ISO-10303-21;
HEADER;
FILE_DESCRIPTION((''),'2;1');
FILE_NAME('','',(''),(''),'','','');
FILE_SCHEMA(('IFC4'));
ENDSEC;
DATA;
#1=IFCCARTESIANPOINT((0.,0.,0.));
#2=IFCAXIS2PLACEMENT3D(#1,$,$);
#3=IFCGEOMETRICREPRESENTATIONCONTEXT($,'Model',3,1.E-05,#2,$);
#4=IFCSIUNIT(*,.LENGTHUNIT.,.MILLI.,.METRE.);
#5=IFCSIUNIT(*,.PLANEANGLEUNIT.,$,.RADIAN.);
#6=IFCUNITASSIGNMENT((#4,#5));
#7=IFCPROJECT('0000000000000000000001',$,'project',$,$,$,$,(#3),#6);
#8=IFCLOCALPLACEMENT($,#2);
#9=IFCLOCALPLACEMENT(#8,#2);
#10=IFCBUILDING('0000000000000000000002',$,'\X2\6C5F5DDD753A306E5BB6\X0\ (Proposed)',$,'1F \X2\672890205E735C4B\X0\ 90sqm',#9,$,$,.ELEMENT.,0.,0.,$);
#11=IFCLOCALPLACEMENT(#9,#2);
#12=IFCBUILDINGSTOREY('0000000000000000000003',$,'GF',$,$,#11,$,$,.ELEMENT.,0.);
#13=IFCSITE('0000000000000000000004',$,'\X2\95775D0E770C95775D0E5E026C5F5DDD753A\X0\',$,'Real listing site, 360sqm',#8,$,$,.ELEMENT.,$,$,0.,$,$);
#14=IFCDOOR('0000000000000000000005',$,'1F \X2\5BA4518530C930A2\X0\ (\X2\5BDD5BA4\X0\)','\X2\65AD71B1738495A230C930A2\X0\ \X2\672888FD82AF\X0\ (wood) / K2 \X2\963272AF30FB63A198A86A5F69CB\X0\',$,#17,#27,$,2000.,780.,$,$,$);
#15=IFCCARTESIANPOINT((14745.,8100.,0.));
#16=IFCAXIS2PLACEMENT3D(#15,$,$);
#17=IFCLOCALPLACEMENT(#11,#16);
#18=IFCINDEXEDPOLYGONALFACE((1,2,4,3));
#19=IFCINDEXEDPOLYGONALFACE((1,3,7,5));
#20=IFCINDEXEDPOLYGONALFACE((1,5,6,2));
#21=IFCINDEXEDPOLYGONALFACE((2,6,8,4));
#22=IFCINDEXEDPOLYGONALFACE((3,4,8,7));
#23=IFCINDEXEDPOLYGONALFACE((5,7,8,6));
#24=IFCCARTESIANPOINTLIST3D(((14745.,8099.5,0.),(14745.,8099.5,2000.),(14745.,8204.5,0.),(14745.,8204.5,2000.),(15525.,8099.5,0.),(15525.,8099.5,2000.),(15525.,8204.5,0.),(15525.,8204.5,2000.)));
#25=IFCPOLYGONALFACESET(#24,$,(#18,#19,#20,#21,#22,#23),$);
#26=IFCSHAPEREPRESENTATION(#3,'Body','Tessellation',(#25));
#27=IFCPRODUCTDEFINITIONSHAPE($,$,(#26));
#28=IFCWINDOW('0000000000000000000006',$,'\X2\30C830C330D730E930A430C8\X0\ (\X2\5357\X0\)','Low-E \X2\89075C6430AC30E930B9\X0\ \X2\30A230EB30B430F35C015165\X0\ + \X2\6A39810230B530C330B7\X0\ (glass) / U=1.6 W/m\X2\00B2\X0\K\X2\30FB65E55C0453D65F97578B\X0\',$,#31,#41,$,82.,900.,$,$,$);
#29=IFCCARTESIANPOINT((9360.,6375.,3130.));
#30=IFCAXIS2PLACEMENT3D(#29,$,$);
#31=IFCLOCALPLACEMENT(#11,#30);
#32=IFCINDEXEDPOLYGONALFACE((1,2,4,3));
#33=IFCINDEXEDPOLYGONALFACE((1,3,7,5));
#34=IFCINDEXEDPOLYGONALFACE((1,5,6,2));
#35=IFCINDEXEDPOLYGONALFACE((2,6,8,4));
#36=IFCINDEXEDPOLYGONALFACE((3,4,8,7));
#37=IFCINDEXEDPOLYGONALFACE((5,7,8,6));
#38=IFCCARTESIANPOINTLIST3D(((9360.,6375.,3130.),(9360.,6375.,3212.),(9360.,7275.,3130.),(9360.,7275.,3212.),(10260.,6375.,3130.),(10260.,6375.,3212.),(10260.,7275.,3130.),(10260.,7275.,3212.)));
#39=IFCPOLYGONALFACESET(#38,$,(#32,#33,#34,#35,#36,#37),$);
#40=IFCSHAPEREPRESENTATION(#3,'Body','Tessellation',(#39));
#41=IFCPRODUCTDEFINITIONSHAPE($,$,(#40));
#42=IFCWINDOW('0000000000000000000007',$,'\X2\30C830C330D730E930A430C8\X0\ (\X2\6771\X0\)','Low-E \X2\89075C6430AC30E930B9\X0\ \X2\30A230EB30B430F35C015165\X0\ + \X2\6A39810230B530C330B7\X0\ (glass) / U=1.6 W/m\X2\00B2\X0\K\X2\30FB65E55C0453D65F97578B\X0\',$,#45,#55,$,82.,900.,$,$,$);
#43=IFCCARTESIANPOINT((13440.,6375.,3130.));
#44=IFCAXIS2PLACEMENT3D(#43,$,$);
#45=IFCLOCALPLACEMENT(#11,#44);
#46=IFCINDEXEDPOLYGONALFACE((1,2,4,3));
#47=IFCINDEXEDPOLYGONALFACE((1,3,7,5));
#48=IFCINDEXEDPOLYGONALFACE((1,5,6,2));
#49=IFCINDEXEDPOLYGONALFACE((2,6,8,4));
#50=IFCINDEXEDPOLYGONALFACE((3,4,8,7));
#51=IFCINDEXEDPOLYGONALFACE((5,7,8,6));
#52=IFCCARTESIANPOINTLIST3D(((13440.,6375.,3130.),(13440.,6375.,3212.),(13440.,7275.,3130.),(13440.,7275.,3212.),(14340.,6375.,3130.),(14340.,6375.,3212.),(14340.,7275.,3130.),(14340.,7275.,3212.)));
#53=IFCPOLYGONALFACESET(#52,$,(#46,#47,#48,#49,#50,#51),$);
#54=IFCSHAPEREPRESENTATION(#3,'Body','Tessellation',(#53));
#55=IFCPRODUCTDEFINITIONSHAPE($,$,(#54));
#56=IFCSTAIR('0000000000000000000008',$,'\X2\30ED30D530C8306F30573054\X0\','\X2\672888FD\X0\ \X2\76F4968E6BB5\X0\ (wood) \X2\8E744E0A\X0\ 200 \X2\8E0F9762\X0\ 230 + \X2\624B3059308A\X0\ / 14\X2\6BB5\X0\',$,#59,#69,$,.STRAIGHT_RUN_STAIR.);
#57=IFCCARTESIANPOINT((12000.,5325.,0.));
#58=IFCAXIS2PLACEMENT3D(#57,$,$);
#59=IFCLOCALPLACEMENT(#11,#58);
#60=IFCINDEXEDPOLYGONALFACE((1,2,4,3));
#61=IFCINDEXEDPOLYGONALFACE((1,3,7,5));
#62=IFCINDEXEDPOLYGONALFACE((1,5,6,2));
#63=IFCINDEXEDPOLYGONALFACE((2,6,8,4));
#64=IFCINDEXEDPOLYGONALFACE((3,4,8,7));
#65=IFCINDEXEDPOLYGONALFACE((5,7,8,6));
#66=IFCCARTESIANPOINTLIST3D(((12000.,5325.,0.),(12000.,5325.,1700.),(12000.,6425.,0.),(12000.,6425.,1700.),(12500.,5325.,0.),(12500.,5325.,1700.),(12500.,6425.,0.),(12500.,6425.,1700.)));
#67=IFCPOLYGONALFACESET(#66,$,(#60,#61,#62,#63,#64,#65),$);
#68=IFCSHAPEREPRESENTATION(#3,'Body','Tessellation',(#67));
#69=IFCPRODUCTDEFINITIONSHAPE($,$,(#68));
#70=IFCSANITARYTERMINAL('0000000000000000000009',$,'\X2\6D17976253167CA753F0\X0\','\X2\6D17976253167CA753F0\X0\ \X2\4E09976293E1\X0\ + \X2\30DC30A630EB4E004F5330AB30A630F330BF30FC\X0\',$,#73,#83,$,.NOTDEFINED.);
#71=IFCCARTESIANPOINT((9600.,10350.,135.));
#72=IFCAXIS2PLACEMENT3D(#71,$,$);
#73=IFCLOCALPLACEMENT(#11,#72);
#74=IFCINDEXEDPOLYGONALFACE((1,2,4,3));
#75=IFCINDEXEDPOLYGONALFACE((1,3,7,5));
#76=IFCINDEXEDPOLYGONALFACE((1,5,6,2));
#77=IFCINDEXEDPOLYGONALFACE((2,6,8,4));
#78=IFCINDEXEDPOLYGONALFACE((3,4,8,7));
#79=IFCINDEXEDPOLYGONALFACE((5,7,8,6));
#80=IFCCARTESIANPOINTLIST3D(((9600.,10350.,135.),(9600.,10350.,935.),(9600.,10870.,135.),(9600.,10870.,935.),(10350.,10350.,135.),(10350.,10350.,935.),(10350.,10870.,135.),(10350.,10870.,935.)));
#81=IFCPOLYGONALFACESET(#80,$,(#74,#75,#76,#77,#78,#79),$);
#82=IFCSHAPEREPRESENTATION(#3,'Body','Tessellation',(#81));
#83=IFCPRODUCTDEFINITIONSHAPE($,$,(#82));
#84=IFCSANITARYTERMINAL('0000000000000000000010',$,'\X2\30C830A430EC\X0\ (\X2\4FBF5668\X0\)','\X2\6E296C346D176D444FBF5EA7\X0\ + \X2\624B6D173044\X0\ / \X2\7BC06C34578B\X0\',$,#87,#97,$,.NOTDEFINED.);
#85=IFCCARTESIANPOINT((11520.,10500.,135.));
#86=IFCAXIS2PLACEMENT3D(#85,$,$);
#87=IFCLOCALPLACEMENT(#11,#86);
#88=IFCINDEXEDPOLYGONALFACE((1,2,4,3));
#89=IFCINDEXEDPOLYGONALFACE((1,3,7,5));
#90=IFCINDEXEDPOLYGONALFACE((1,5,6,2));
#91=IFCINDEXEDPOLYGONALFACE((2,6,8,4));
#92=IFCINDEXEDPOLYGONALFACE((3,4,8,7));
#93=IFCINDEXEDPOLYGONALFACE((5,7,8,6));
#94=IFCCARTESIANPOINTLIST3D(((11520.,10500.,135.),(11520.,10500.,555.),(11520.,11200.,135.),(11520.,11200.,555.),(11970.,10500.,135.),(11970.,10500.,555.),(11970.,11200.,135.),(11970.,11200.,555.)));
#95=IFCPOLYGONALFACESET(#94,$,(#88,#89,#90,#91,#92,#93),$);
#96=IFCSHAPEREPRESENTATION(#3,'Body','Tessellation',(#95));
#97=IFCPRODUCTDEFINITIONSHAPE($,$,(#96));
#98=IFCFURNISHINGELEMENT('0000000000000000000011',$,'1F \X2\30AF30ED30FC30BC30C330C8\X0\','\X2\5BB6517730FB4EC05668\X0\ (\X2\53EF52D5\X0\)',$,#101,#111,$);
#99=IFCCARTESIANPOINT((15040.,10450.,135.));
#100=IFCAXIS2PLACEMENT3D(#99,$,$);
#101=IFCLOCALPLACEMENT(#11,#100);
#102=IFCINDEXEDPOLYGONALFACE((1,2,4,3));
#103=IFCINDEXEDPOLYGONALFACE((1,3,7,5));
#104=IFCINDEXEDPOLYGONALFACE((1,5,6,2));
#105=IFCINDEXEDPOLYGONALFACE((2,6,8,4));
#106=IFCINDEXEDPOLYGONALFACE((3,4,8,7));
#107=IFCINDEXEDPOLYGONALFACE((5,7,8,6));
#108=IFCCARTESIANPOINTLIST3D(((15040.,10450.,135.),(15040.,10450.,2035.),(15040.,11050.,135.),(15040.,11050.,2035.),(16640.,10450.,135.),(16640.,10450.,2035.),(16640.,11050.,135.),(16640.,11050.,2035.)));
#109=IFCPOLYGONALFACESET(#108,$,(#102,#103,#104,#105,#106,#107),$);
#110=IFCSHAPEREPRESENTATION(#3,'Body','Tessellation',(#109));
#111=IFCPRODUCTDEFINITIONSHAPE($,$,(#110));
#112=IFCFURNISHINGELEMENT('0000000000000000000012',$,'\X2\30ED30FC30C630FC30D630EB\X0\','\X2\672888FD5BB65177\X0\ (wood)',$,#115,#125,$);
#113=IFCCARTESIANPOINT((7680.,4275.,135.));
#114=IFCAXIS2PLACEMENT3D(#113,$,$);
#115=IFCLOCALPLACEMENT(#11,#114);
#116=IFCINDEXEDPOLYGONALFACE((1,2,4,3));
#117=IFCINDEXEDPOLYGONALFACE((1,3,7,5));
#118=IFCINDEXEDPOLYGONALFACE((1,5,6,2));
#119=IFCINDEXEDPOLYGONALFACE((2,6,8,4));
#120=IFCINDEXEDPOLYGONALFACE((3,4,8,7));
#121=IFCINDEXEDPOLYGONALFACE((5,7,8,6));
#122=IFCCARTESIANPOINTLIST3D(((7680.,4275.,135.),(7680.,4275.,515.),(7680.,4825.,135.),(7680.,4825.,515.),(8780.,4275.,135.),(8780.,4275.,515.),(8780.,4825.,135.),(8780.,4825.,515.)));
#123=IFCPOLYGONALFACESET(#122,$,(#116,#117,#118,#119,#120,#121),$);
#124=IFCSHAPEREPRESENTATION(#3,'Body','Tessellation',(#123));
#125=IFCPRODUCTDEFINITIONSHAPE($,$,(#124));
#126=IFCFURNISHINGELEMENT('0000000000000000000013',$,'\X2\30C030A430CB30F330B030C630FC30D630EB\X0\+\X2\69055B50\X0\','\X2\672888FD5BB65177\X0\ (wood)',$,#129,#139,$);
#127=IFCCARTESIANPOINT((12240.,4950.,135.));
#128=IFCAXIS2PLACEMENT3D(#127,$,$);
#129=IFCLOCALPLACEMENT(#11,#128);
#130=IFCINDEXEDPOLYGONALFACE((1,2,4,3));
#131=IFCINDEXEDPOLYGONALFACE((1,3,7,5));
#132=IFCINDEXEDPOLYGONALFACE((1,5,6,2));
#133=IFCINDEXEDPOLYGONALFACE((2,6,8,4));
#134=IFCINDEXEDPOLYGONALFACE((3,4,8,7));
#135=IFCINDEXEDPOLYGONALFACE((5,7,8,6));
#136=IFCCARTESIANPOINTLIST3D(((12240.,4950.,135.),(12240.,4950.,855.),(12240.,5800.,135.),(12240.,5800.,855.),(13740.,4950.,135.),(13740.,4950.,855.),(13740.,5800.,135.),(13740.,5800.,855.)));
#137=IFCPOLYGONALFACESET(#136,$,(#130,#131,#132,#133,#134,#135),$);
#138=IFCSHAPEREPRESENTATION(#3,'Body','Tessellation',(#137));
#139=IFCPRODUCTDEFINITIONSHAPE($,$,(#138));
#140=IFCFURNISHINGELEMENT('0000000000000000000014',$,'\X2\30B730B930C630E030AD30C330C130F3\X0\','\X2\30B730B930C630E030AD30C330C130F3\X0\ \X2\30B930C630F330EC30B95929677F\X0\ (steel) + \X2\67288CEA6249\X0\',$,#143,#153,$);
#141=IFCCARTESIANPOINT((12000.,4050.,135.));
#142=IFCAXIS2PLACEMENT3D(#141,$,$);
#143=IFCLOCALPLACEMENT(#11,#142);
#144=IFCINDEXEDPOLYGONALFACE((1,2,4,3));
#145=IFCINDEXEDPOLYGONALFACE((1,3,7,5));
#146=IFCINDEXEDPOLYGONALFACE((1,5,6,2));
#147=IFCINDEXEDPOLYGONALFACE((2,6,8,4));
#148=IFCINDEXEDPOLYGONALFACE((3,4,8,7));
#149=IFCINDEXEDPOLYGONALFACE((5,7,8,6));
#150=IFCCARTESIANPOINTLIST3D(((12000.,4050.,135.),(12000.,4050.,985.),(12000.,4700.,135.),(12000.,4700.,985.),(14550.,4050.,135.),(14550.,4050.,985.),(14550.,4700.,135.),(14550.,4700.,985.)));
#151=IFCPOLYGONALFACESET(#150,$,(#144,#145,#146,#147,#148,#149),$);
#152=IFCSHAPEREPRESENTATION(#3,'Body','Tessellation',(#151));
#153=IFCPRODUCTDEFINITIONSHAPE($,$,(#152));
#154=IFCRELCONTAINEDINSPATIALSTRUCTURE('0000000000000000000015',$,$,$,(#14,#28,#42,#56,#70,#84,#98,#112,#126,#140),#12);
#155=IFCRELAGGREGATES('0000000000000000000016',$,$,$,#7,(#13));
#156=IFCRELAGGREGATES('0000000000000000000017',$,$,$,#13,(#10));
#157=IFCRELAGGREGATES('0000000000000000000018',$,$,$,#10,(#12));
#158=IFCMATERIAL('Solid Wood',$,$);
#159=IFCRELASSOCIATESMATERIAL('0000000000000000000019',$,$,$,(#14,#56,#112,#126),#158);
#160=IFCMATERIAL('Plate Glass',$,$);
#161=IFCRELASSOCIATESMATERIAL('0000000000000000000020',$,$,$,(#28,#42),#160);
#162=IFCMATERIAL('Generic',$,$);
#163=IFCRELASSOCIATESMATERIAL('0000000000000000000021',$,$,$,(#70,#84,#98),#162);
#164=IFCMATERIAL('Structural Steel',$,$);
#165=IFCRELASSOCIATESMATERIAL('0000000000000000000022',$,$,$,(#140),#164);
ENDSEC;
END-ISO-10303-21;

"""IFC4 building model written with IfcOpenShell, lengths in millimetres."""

from ifc_helpers import new_model, si_unit, frame, frame_2d, origin, place, context, project, spatial, rectangle, extrude, material, element, save


model = new_model("IFC4")

# Units and contexts
model_context = context("Model", 3, precision=1e-05, world=origin())
ifc_project = project(units=[si_unit("LENGTHUNIT", "METRE", prefix="MILLI"), si_unit("PLANEANGLEUNIT", "RADIAN")], contexts=[model_context])

# Site, building, storey
site_placement = place(None, origin())
site = spatial("IfcSite", under=ifc_project, at=site_placement, Name="長崎県長崎市江川町", ObjectType="Real listing site, 360sqm", CompositionType="ELEMENT", RefElevation=0.0)
building_placement = place(site_placement, origin())
building = spatial("IfcBuilding", under=site, at=building_placement, Name="江川町の家 (Proposed)", ObjectType="1F 木造平屋 90sqm", CompositionType="ELEMENT", ElevationOfRefHeight=0.0, ElevationOfTerrain=0.0)
storey_placement = place(building_placement, origin())
storey = spatial("IfcBuildingStorey", under=building, at=storey_placement, Name="GF", CompositionType="ELEMENT", Elevation=0.0)

# Shared definitions
ifc_material_1 = material(Name="Solid Wood")
ifc_material_2 = material(Name="Plate Glass")

# Door
door_placement = place(storey_placement, frame((14745.0, 8100.0, 0.0)))
element("IfcDoor", 1, at=door_placement, inside=storey, material=ifc_material_1, Name="1F 室内ドア (寝室)", Description="断熱玄関ドア 木製芯 (wood) / K2 防犯・採風機構", OverallHeight=2000.0, OverallWidth=780.0, context=model_context, shape_type="SweptSolid", body=[
    extrude(rectangle(XDim=780.0, YDim=105.0, at=frame_2d((390.0, 52.0))), frame((14745.0, 8100.0, 0.0)), (0.0, 0.0, 1.0), 2000.0),
])

# Windows
window_1_placement = place(storey_placement, frame((9360.0, 6375.0, 3130.0)))
element("IfcWindow", 2, at=window_1_placement, inside=storey, material=ifc_material_2, Name="トップライト (南)", Description="Low-E 複層ガラス アルゴン封入 + 樹脂サッシ (glass) / U=1.6 W/m²K・日射取得型", OverallHeight=82.0, OverallWidth=900.0, context=model_context, shape_type="SweptSolid", body=[
    extrude(rectangle(XDim=900.0, YDim=900.0, at=frame_2d((450.0, 450.0))), frame((9360.0, 6375.0, 3130.0)), (0.0, 0.0, 1.0), 82.0),
])
window_2_placement = place(storey_placement, frame((13440.0, 6375.0, 3130.0)))
element("IfcWindow", 3, at=window_2_placement, inside=storey, material=ifc_material_2, Name="トップライト (東)", Description="Low-E 複層ガラス アルゴン封入 + 樹脂サッシ (glass) / U=1.6 W/m²K・日射取得型", OverallHeight=82.0, OverallWidth=900.0, context=model_context, shape_type="SweptSolid", body=[
    extrude(rectangle(XDim=900.0, YDim=900.0, at=frame_2d((450.0, 450.0))), frame((13440.0, 6375.0, 3130.0)), (0.0, 0.0, 1.0), 82.0),
])

# Stair
stair_placement = place(storey_placement, frame((12000.0, 5325.0, 0.0)))
element("IfcStair", 4, at=stair_placement, inside=storey, material=ifc_material_1, Name="ロフトはしご", Description="木製 直階段 (wood) 蹴上 200 踏面 230 + 手すり / 14段", PredefinedType="STRAIGHT_RUN_STAIR", context=model_context, shape_type="SweptSolid", body=[
    extrude(rectangle(XDim=500.0, YDim=1100.0, at=frame_2d((250.0, 550.0))), frame((12000.0, 5325.0, 0.0)), (0.0, 0.0, 1.0), 1700.0),
])

# Sanitary terminals
ifc_material_3 = material(Name="Generic")
sanitary_terminal_1_placement = place(storey_placement, frame((9600.0, 10350.0, 135.0)))
element("IfcSanitaryTerminal", 5, at=sanitary_terminal_1_placement, inside=storey, material=ifc_material_3, Name="洗面化粧台", Description="洗面化粧台 三面鏡 + ボウル一体カウンター", PredefinedType="NOTDEFINED", context=model_context, shape_type="SweptSolid", body=[
    extrude(rectangle(XDim=750.0, YDim=520.0, at=frame_2d((375.0, 260.0))), frame((9600.0, 10350.0, 135.0)), (0.0, 0.0, 1.0), 800.0),
])
sanitary_terminal_2_placement = place(storey_placement, frame((11520.0, 10500.0, 135.0)))
element("IfcSanitaryTerminal", 6, at=sanitary_terminal_2_placement, inside=storey, material=ifc_material_3, Name="トイレ (便器)", Description="温水洗浄便座 + 手洗い / 節水型", PredefinedType="NOTDEFINED", context=model_context, shape_type="SweptSolid", body=[
    extrude(rectangle(XDim=450.0, YDim=700.0, at=frame_2d((225.0, 350.0))), frame((11520.0, 10500.0, 135.0)), (0.0, 0.0, 1.0), 420.0),
])

# Furnishing elements
furnishing_1_placement = place(storey_placement, frame((15040.0, 10450.0, 135.0)))
element("IfcFurnishingElement", 7, at=furnishing_1_placement, inside=storey, material=ifc_material_3, Name="1F クローゼット", Description="家具・什器 (可動)", context=model_context, shape_type="SweptSolid", body=[
    extrude(rectangle(XDim=1600.0, YDim=600.0, at=frame_2d((800.0, 300.0))), frame((15040.0, 10450.0, 135.0)), (0.0, 0.0, 1.0), 1900.0),
])
furnishing_2_placement = place(storey_placement, frame((7680.0, 4275.0, 135.0)))
element("IfcFurnishingElement", 8, at=furnishing_2_placement, inside=storey, material=ifc_material_1, Name="ローテーブル", Description="木製家具 (wood)", context=model_context, shape_type="SweptSolid", body=[
    extrude(rectangle(XDim=1100.0, YDim=550.0, at=frame_2d((550.0, 275.0))), frame((7680.0, 4275.0, 135.0)), (0.0, 0.0, 1.0), 380.0),
])
furnishing_3_placement = place(storey_placement, frame((12240.0, 4950.0, 135.0)))
element("IfcFurnishingElement", 9, at=furnishing_3_placement, inside=storey, material=ifc_material_1, Name="ダイニングテーブル+椅子", Description="木製家具 (wood)", context=model_context, shape_type="SweptSolid", body=[
    extrude(rectangle(XDim=1500.0, YDim=850.0, at=frame_2d((750.0, 425.0))), frame((12240.0, 4950.0, 135.0)), (0.0, 0.0, 1.0), 720.0),
])
ifc_material_4 = material(Name="Structural Steel")
furnishing_4_placement = place(storey_placement, frame((12000.0, 4050.0, 135.0)))
element("IfcFurnishingElement", 10, at=furnishing_4_placement, inside=storey, material=ifc_material_4, Name="システムキッチン", Description="システムキッチン ステンレス天板 (steel) + 木質扉", context=model_context, shape_type="SweptSolid", body=[
    extrude(rectangle(XDim=2550.0, YDim=650.0, at=frame_2d((1275.0, 325.0))), frame((12000.0, 4050.0, 135.0)), (0.0, 0.0, 1.0), 850.0),
])

save(model, "model.ifc")
